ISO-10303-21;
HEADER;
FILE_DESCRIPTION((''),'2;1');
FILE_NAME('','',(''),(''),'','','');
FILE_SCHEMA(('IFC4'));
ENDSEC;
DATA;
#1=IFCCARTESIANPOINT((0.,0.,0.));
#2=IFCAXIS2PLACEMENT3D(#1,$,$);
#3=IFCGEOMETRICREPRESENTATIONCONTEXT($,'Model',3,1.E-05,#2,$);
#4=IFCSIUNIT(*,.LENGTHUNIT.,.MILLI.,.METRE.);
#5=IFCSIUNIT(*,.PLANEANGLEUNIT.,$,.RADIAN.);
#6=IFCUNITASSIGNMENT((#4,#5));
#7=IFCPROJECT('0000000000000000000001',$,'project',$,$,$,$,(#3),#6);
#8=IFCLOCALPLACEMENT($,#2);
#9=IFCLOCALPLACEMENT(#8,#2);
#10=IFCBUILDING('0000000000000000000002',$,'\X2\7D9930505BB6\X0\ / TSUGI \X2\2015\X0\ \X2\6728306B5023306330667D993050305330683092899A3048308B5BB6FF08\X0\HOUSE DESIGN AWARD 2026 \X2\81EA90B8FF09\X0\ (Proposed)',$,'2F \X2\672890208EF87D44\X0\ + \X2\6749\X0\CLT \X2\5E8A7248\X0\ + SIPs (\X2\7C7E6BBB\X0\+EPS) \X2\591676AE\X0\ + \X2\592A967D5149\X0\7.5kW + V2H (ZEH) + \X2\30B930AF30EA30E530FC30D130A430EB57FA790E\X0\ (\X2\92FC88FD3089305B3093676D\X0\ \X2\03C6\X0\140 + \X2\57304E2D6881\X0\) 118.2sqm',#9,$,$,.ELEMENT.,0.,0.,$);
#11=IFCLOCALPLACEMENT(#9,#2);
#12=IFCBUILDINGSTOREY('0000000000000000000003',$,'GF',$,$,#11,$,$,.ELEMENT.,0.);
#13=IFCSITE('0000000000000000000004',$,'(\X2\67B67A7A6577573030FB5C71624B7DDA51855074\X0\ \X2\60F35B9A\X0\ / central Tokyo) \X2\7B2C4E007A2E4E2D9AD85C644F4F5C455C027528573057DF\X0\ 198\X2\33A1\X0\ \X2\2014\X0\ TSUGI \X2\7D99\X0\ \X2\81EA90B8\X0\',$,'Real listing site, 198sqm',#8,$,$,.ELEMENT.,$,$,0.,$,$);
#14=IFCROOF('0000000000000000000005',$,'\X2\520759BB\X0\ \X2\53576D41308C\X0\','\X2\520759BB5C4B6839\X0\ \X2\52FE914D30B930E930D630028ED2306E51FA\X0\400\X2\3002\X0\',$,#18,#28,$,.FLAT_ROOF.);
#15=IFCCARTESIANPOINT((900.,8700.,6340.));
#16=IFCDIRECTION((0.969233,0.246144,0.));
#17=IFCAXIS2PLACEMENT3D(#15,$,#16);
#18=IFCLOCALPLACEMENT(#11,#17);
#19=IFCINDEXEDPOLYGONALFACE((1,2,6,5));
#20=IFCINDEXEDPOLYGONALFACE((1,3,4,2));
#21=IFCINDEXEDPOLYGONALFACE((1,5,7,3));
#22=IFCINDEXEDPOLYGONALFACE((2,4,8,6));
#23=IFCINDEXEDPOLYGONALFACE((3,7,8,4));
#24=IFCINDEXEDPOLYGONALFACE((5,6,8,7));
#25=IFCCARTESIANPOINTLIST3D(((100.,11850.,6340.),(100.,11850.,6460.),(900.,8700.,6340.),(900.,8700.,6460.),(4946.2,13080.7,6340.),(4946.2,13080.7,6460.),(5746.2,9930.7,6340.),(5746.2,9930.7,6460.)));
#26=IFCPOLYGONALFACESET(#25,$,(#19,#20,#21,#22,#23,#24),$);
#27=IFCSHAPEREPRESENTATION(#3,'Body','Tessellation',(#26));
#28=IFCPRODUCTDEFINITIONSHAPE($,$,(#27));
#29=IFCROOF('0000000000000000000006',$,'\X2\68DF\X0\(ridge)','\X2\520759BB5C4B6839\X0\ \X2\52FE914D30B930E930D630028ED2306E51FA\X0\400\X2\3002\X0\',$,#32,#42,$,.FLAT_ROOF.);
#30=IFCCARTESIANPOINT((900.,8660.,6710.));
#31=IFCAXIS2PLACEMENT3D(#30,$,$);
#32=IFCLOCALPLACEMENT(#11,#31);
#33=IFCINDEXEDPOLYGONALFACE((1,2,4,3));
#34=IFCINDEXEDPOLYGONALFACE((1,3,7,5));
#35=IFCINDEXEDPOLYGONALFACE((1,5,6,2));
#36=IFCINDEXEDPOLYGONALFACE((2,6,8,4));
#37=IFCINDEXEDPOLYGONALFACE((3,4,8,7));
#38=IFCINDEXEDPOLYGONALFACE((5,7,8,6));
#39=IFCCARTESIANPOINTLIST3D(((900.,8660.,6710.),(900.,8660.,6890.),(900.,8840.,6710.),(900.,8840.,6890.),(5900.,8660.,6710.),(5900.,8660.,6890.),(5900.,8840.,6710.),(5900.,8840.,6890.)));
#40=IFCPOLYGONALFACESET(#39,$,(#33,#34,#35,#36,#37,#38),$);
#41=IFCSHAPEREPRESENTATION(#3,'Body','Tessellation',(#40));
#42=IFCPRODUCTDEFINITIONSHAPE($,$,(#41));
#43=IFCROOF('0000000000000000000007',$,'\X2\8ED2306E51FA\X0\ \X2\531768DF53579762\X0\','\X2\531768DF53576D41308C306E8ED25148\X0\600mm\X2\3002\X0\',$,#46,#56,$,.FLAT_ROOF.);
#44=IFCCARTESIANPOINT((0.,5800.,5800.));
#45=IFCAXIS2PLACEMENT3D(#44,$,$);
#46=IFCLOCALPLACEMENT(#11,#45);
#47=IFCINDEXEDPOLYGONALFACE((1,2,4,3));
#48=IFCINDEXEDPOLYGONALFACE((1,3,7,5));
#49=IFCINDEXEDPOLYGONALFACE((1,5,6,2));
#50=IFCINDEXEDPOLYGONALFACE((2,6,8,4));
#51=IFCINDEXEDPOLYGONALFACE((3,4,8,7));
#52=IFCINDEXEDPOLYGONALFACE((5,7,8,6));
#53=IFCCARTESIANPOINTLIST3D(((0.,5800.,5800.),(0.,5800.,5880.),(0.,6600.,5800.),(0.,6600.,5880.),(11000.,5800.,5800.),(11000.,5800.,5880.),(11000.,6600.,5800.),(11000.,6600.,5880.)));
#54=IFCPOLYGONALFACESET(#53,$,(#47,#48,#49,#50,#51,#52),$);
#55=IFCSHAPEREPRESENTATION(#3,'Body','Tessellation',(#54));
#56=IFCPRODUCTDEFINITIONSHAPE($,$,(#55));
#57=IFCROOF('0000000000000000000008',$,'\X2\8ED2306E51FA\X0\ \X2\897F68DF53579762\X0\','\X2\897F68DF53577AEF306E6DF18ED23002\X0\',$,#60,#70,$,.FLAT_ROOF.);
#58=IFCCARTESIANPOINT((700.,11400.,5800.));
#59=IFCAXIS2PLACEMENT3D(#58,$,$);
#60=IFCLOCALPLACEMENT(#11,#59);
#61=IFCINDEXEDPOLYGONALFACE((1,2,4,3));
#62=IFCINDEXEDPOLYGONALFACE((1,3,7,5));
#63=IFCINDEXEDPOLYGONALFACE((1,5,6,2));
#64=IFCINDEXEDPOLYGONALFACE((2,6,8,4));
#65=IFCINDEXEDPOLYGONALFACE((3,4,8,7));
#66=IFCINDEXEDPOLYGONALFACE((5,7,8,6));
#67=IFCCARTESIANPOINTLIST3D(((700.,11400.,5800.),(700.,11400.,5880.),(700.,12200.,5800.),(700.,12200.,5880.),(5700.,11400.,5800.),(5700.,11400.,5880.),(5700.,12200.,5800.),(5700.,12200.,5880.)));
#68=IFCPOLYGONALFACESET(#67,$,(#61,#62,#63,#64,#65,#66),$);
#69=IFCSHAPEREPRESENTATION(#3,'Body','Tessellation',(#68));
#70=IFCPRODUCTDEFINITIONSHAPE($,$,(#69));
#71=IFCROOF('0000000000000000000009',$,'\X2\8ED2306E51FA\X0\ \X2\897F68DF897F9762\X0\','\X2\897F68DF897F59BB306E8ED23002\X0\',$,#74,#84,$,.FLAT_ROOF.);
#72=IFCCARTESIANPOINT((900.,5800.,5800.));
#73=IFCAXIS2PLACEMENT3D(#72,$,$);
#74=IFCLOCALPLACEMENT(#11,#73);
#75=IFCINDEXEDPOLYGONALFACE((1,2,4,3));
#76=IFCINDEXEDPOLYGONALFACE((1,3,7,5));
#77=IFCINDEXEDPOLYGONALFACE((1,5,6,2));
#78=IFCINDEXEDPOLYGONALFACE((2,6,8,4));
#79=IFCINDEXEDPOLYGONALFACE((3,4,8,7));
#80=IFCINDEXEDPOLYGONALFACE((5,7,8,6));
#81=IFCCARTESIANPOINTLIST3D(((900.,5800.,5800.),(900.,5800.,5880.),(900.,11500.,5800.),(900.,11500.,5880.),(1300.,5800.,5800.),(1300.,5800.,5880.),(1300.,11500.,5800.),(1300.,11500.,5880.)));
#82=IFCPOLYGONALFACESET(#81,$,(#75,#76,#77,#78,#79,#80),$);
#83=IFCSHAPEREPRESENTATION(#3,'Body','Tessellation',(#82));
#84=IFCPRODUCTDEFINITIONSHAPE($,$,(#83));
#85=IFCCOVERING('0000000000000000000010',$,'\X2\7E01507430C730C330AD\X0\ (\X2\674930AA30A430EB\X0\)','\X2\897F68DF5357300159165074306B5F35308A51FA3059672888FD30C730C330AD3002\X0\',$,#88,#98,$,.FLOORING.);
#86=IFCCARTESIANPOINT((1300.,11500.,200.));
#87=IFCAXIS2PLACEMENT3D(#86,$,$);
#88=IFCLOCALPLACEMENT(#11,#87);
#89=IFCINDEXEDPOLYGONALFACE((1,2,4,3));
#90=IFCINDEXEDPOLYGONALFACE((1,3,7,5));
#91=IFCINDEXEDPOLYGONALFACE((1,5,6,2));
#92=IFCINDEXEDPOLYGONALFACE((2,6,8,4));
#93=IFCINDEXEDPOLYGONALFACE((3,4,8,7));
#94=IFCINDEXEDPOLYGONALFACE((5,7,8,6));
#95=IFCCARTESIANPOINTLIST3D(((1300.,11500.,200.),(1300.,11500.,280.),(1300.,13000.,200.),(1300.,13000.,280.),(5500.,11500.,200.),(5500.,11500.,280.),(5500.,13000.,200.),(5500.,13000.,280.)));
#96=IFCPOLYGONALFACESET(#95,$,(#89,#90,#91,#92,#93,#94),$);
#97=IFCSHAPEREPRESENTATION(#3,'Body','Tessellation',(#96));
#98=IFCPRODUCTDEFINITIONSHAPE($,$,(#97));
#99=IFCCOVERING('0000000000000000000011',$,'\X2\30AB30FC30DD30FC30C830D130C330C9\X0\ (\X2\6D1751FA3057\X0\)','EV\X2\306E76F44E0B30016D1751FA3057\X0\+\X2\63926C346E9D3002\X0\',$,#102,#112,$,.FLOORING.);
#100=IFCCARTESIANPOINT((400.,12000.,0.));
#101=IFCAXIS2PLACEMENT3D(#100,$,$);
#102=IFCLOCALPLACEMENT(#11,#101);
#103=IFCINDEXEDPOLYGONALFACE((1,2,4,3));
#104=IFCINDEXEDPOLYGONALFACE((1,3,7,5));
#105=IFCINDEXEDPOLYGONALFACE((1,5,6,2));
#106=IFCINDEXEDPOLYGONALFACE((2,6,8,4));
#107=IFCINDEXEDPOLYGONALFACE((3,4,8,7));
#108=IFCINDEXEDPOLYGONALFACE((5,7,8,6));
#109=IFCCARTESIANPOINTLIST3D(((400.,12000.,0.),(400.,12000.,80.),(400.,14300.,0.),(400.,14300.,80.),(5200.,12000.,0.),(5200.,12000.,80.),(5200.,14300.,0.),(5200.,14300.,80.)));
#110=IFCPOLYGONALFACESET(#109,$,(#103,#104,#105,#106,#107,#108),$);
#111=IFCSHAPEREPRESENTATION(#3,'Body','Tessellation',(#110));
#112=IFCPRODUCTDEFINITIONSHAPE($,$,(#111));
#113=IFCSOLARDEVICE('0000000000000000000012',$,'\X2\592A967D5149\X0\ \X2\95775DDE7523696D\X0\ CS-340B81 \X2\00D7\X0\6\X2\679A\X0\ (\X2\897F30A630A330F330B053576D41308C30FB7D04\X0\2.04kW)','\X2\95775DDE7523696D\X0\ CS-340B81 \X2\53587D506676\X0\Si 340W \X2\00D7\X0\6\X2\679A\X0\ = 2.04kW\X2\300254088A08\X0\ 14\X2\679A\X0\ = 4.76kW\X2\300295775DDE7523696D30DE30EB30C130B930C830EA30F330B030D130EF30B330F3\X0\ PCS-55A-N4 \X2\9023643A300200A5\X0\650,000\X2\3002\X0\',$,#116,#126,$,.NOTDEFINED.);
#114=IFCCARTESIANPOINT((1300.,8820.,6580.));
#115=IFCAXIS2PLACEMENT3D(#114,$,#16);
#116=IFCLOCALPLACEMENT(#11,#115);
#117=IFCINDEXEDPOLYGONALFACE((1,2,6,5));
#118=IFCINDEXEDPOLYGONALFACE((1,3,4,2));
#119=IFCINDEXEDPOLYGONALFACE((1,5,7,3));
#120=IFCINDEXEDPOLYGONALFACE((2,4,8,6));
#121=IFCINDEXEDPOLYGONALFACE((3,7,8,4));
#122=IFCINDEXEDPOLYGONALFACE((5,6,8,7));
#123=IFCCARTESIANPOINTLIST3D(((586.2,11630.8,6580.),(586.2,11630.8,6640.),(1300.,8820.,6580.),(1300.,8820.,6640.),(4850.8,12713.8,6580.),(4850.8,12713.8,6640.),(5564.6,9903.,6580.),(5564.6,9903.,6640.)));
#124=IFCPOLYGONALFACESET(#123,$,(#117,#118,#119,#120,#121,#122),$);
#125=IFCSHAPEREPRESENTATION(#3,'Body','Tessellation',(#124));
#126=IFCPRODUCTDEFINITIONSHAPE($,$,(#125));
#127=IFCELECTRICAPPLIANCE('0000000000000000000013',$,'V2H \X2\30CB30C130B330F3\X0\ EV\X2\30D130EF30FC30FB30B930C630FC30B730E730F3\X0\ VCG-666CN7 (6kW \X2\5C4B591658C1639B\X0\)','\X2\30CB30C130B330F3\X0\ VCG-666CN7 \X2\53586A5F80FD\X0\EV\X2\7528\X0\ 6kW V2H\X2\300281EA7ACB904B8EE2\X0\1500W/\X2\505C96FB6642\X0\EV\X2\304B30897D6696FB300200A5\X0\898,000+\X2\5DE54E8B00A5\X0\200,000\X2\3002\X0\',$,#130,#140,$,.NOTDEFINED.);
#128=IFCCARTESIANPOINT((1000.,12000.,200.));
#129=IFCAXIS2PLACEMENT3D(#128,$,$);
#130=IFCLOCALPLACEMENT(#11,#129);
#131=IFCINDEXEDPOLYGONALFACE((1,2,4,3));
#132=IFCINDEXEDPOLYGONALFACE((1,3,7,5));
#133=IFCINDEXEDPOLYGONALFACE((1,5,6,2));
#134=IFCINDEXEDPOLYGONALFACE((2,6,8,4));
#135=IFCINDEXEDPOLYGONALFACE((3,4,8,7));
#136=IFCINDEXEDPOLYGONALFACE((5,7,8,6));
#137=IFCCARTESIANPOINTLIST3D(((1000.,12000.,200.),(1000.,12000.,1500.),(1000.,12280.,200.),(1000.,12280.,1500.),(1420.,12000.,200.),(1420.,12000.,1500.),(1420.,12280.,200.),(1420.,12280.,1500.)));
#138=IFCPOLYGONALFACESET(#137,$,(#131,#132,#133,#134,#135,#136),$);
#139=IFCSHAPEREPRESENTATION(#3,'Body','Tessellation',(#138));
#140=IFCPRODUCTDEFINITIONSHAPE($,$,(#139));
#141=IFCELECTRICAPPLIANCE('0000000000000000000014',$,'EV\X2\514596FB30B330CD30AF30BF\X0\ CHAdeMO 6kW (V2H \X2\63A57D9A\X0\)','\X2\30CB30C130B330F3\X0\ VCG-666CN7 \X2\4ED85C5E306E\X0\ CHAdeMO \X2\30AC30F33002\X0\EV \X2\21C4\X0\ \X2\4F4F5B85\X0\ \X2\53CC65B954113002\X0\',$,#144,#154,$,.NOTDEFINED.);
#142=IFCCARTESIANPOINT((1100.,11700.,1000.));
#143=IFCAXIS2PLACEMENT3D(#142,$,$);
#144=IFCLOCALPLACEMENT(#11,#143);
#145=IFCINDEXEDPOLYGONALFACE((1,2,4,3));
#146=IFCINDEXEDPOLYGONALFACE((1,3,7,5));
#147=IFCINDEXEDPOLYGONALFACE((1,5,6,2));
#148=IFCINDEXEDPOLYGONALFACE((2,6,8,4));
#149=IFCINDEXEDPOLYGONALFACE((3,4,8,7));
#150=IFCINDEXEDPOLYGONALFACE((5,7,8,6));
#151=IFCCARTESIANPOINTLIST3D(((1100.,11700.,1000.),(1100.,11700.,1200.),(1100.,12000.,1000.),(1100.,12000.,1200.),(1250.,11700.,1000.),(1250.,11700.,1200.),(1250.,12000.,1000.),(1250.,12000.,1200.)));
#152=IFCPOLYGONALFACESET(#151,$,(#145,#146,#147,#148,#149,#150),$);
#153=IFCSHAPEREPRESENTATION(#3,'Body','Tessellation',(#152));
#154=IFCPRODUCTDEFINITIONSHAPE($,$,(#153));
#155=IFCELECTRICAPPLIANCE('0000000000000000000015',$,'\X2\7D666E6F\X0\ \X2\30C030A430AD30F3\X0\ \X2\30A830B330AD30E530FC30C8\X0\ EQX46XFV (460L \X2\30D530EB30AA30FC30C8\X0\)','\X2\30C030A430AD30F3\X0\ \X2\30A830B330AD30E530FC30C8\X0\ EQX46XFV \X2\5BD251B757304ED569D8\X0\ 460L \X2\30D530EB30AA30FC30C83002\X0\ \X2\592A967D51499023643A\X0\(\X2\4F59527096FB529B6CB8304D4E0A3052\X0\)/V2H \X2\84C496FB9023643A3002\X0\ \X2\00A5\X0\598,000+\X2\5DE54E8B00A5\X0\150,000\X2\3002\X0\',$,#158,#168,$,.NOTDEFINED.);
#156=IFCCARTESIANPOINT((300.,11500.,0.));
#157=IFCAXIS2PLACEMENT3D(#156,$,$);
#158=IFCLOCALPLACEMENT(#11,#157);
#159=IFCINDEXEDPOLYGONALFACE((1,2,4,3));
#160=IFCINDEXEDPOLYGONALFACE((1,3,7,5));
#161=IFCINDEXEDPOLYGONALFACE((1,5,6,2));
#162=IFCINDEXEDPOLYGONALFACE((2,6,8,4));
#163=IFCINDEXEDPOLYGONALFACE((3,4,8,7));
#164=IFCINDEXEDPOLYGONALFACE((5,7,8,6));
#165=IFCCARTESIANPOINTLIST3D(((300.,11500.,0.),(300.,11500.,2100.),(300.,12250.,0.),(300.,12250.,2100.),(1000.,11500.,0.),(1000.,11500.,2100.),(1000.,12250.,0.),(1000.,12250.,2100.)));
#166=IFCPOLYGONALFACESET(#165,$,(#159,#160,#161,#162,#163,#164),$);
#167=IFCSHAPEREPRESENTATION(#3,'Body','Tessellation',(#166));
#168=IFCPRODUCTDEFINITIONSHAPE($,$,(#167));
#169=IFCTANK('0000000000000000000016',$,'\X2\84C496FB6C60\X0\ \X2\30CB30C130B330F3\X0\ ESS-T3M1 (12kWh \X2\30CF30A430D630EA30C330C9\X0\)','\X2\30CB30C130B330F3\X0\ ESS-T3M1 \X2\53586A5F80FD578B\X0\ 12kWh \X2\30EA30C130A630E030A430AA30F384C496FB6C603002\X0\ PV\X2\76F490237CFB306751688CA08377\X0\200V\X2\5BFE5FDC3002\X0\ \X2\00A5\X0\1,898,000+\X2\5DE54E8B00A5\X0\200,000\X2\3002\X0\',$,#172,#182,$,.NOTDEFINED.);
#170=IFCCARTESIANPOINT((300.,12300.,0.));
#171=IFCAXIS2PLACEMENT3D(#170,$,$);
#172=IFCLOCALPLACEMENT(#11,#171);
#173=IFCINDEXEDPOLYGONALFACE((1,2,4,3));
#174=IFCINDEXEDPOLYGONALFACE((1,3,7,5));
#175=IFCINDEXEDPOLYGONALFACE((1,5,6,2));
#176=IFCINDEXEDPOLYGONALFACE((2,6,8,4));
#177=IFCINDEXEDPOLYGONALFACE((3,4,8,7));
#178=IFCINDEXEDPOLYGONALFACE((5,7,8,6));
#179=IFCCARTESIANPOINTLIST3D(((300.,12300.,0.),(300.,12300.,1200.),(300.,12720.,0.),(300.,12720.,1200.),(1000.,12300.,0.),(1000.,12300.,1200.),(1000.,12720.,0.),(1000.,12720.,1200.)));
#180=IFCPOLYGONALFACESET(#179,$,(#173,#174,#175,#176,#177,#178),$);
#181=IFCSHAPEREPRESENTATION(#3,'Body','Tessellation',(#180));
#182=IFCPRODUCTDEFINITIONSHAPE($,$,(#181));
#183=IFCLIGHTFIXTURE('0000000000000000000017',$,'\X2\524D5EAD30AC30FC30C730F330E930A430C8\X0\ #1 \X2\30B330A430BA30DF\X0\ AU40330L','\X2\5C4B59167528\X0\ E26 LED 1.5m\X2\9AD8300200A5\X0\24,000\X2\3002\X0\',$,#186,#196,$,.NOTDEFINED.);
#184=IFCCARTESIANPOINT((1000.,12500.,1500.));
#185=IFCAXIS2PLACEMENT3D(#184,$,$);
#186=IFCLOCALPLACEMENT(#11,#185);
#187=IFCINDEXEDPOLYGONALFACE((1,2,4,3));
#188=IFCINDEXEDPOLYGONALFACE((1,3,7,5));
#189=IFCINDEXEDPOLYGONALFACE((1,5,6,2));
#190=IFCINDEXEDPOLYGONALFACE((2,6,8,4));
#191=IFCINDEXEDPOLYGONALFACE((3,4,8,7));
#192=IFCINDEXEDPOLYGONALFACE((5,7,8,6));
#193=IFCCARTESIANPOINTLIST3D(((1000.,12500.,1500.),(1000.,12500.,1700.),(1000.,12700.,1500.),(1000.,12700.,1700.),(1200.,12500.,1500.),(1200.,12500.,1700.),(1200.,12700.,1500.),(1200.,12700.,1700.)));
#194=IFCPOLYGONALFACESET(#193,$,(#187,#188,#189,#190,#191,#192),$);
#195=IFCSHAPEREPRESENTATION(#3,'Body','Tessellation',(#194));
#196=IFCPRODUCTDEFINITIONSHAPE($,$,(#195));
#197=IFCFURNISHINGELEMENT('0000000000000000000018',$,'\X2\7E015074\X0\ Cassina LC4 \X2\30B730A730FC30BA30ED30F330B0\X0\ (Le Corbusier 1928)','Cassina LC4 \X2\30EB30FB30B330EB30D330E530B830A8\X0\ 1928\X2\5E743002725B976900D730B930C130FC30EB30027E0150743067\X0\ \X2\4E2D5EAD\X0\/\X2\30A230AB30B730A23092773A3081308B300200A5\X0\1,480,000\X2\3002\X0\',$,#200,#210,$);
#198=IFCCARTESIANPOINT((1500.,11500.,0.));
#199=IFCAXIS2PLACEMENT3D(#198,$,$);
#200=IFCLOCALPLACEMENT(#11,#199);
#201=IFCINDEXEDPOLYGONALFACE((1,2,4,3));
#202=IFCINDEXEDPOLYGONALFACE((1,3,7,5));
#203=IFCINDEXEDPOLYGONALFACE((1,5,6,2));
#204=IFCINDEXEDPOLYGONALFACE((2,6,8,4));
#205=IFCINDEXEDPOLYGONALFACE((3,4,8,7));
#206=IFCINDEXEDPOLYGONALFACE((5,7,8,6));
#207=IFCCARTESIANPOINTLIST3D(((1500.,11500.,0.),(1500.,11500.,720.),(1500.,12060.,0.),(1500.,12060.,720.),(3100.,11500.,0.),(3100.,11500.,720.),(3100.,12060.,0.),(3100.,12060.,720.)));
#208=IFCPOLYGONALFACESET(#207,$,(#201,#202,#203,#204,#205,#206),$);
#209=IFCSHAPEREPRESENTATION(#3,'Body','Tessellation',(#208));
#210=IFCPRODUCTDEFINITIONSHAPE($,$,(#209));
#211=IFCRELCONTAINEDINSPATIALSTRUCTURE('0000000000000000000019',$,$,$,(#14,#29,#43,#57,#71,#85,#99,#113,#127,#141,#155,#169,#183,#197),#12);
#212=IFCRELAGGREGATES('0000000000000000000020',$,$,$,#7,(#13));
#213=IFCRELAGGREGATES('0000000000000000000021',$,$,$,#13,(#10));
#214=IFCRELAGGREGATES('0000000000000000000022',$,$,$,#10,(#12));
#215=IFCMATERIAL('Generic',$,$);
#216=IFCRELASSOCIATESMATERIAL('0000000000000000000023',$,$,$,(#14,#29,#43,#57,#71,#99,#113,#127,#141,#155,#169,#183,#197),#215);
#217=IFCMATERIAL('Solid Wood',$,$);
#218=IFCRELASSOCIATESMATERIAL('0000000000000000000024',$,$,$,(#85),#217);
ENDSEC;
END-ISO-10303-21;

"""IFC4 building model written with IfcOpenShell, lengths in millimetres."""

from ifc_helpers import new_model, si_unit, frame, frame_2d, origin, place, context, project, spatial, rectangle, extrude, material, element, save


model = new_model("IFC4")

# Units and contexts
model_context = context("Model", 3, precision=1e-05, world=origin())
ifc_project = project(units=[si_unit("LENGTHUNIT", "METRE", prefix="MILLI"), si_unit("PLANEANGLEUNIT", "RADIAN")], contexts=[model_context])

# Site, building, storey
site_placement = place(None, origin())
site = spatial("IfcSite", under=ifc_project, at=site_placement, Name="(架空敷地・山手線内側 想定 / central Tokyo) 第一種中高層住居専用地域 198㎡ — TSUGI 継 自邸", ObjectType="Real listing site, 198sqm", CompositionType="ELEMENT", RefElevation=0.0)
building_placement = place(site_placement, origin())
building = spatial("IfcBuilding", under=site, at=building_placement, Name="継ぐ家 / TSUGI ― 木に倣って継ぐことを覚える家（HOUSE DESIGN AWARD 2026 自邸） (Proposed)", ObjectType="2F 木造軸組 + 杉CLT 床版 + SIPs (籾殻+EPS) 外皮 + 太陽光7.5kW + V2H (ZEH) + スクリューパイル基礎 (鋼製らせん杭 φ140 + 地中梁) 118.2sqm", CompositionType="ELEMENT", ElevationOfRefHeight=0.0, ElevationOfTerrain=0.0)
storey_placement = place(building_placement, origin())
storey = spatial("IfcBuildingStorey", under=building, at=storey_placement, Name="GF", CompositionType="ELEMENT", Elevation=0.0)

# Shared definitions
ifc_material_1 = material(Name="Generic")

# Shared definitions
ifc_material_2 = material(Name="Solid Wood")

# Roofs
roof_1_placement = place(storey_placement, frame((900.0, 8700.0, 6340.0), x_axis=(0.969233, 0.246144, 0.0)))
element("IfcRoof", 1, at=roof_1_placement, inside=storey, material=ifc_material_1, Name="切妻 南流れ", Description="切妻屋根 勾配スラブ。軒の出400。", PredefinedType="FLAT_ROOF", context=model_context, shape_type="SweptSolid", body=[
    extrude(rectangle(XDim=5000.0, YDim=3250.0, at=frame_2d((2500.0, 1625.0))), frame((900.0, 8700.0, 6340.0), x_axis=(0.969233, 0.246144, 0.0)), (0.0, 0.0, 1.0), 120.0),
])
roof_2_placement = place(storey_placement, frame((900.0, 8660.0, 6710.0)))
element("IfcRoof", 2, at=roof_2_placement, inside=storey, material=ifc_material_1, Name="棟(ridge)", Description="切妻屋根 勾配スラブ。軒の出400。", PredefinedType="FLAT_ROOF", context=model_context, shape_type="SweptSolid", body=[
    extrude(rectangle(XDim=5000.0, YDim=180.0, at=frame_2d((2500.0, 90.0))), frame((900.0, 8660.0, 6710.0)), (0.0, 0.0, 1.0), 180.0),
])
roof_3_placement = place(storey_placement, frame((0.0, 5800.0, 5800.0)))
element("IfcRoof", 3, at=roof_3_placement, inside=storey, material=ifc_material_1, Name="軒の出 北棟南面", Description="北棟南流れの軒先600mm。", PredefinedType="FLAT_ROOF", context=model_context, shape_type="SweptSolid", body=[
    extrude(rectangle(XDim=11000.0, YDim=800.0, at=frame_2d((5500.0, 400.0))), frame((0.0, 5800.0, 5800.0)), (0.0, 0.0, 1.0), 80.0),
])
roof_4_placement = place(storey_placement, frame((700.0, 11400.0, 5800.0)))
element("IfcRoof", 4, at=roof_4_placement, inside=storey, material=ifc_material_1, Name="軒の出 西棟南面", Description="西棟南端の深軒。", PredefinedType="FLAT_ROOF", context=model_context, shape_type="SweptSolid", body=[
    extrude(rectangle(XDim=5000.0, YDim=800.0, at=frame_2d((2500.0, 400.0))), frame((700.0, 11400.0, 5800.0)), (0.0, 0.0, 1.0), 80.0),
])
roof_5_placement = place(storey_placement, frame((900.0, 5800.0, 5800.0)))
element("IfcRoof", 5, at=roof_5_placement, inside=storey, material=ifc_material_1, Name="軒の出 西棟西面", Description="西棟西妻の軒。", PredefinedType="FLAT_ROOF", context=model_context, shape_type="SweptSolid", body=[
    extrude(rectangle(XDim=400.0, YDim=5700.0, at=frame_2d((200.0, 2850.0))), frame((900.0, 5800.0, 5800.0)), (0.0, 0.0, 1.0), 80.0),
])

# Coverings
covering_1_placement = place(storey_placement, frame((1300.0, 11500.0, 200.0)))
element("IfcCovering", 6, at=covering_1_placement, inside=storey, material=ifc_material_2, Name="縁側デッキ (杉オイル)", Description="西棟南、外側に張り出す木製デッキ。", PredefinedType="FLOORING", context=model_context, shape_type="SweptSolid", body=[
    extrude(rectangle(XDim=4200.0, YDim=1500.0, at=frame_2d((2100.0, 750.0))), frame((1300.0, 11500.0, 200.0)), (0.0, 0.0, 1.0), 80.0),
])
covering_2_placement = place(storey_placement, frame((400.0, 12000.0, 0.0)))
element("IfcCovering", 7, at=covering_2_placement, inside=storey, material=ifc_material_1, Name="カーポートパッド (洗出し)", Description="EVの直下、洗出し+排水溝。", PredefinedType="FLOORING", context=model_context, shape_type="SweptSolid", body=[
    extrude(rectangle(XDim=4800.0, YDim=2300.0, at=frame_2d((2400.0, 1150.0))), frame((400.0, 12000.0, 0.0)), (0.0, 0.0, 1.0), 80.0),
])

# Solar device
solar_device_placement = place(storey_placement, frame((1300.0, 8820.0, 6580.0), x_axis=(0.969233, 0.246144, 0.0)))
element("IfcSolarDevice", 8, at=solar_device_placement, inside=storey, material=ifc_material_1, Name="太陽光 長州産業 CS-340B81 ×6枚 (西ウィング南流れ・約2.04kW)", Description="長州産業 CS-340B81 単結晶Si 340W ×6枚 = 2.04kW。合計 14枚 = 4.76kW。長州産業マルチストリングパワコン PCS-55A-N4 連携。¥650,000。", PredefinedType="NOTDEFINED", context=model_context, shape_type="SweptSolid", body=[
    extrude(rectangle(XDim=4400.0, YDim=2900.0, at=frame_2d((2200.0, 1450.0))), frame((1300.0, 8820.0, 6580.0), x_axis=(0.969233, 0.246144, 0.0)), (0.0, 0.0, 1.0), 60.0),
])

# Electric appliances
electric_appliance_1_placement = place(storey_placement, frame((1000.0, 12000.0, 200.0)))
element("IfcElectricAppliance", 9, at=electric_appliance_1_placement, inside=storey, material=ifc_material_1, Name="V2H ニチコン EVパワー・ステーション VCG-666CN7 (6kW 屋外壁掛)", Description="ニチコン VCG-666CN7 単機能EV用 6kW V2H。自立運転1500W/停電時EVから給電。¥898,000+工事¥200,000。", PredefinedType="NOTDEFINED", context=model_context, shape_type="SweptSolid", body=[
    extrude(rectangle(XDim=420.0, YDim=280.0, at=frame_2d((210.0, 140.0))), frame((1000.0, 12000.0, 200.0)), (0.0, 0.0, 1.0), 1300.0),
])
electric_appliance_2_placement = place(storey_placement, frame((1100.0, 11700.0, 1000.0)))
element("IfcElectricAppliance", 10, at=electric_appliance_2_placement, inside=storey, material=ifc_material_1, Name="EV充電コネクタ CHAdeMO 6kW (V2H 接続)", Description="ニチコン VCG-666CN7 付属の CHAdeMO ガン。EV ⇄ 住宅 双方向。", PredefinedType="NOTDEFINED", context=model_context, shape_type="SweptSolid", body=[
    extrude(rectangle(XDim=150.0, YDim=300.0, at=frame_2d((75.0, 150.0))), frame((1100.0, 11700.0, 1000.0)), (0.0, 0.0, 1.0), 200.0),
])
electric_appliance_3_placement = place(storey_placement, frame((300.0, 11500.0, 0.0)))
element("IfcElectricAppliance", 11, at=electric_appliance_3_placement, inside=storey, material=ifc_material_1, Name="給湯 ダイキン エコキュート EQX46XFV (460L フルオート)", Description="ダイキン エコキュート EQX46XFV 寒冷地仕様 460L フルオート。 太陽光連携(余剰電力沸き上げ)/V2H 蓄電連携。 ¥598,000+工事¥150,000。", PredefinedType="NOTDEFINED", context=model_context, shape_type="SweptSolid", body=[
    extrude(rectangle(XDim=700.0, YDim=750.0, at=frame_2d((350.0, 375.0))), frame((300.0, 11500.0, 0.0)), (0.0, 0.0, 1.0), 2100.0),
])

# Tank
tank_placement = place(storey_placement, frame((300.0, 12300.0, 0.0)))
element("IfcTank", 12, at=tank_placement, inside=storey, material=ifc_material_1, Name="蓄電池 ニチコン ESS-T3M1 (12kWh ハイブリッド)", Description="ニチコン ESS-T3M1 単機能型 12kWh リチウムイオン蓄電池。 PV直連系で全負荷200V対応。 ¥1,898,000+工事¥200,000。", PredefinedType="NOTDEFINED", context=model_context, shape_type="SweptSolid", body=[
    extrude(rectangle(XDim=700.0, YDim=420.0, at=frame_2d((350.0, 210.0))), frame((300.0, 12300.0, 0.0)), (0.0, 0.0, 1.0), 1200.0),
])

# Light fixture
light_fixture_placement = place(storey_placement, frame((1000.0, 12500.0, 1500.0)))
element("IfcLightFixture", 13, at=light_fixture_placement, inside=storey, material=ifc_material_1, Name="前庭ガーデンライト #1 コイズミ AU40330L", Description="屋外用 E26 LED 1.5m高。¥24,000。", PredefinedType="NOTDEFINED", context=model_context, shape_type="SweptSolid", body=[
    extrude(rectangle(XDim=200.0, YDim=200.0, at=frame_2d((100.0, 100.0))), frame((1000.0, 12500.0, 1500.0)), (0.0, 0.0, 1.0), 200.0),
])

# Furnishing element
furnishing_1_placement = place(storey_placement, frame((1500.0, 11500.0, 0.0)))
element("IfcFurnishingElement", 14, at=furnishing_1_placement, inside=storey, material=ifc_material_1, Name="縁側 Cassina LC4 シェーズロング (Le Corbusier 1928)", Description="Cassina LC4 ル・コルビュジエ 1928年。牛革×スチール。縁側で 中庭/アカシアを眺める。¥1,480,000。", context=model_context, shape_type="SweptSolid", body=[
    extrude(rectangle(XDim=1600.0, YDim=560.0, at=frame_2d((800.0, 280.0))), frame((1500.0, 11500.0, 0.0)), (0.0, 0.0, 1.0), 720.0),
])

save(model, "model.ifc")
